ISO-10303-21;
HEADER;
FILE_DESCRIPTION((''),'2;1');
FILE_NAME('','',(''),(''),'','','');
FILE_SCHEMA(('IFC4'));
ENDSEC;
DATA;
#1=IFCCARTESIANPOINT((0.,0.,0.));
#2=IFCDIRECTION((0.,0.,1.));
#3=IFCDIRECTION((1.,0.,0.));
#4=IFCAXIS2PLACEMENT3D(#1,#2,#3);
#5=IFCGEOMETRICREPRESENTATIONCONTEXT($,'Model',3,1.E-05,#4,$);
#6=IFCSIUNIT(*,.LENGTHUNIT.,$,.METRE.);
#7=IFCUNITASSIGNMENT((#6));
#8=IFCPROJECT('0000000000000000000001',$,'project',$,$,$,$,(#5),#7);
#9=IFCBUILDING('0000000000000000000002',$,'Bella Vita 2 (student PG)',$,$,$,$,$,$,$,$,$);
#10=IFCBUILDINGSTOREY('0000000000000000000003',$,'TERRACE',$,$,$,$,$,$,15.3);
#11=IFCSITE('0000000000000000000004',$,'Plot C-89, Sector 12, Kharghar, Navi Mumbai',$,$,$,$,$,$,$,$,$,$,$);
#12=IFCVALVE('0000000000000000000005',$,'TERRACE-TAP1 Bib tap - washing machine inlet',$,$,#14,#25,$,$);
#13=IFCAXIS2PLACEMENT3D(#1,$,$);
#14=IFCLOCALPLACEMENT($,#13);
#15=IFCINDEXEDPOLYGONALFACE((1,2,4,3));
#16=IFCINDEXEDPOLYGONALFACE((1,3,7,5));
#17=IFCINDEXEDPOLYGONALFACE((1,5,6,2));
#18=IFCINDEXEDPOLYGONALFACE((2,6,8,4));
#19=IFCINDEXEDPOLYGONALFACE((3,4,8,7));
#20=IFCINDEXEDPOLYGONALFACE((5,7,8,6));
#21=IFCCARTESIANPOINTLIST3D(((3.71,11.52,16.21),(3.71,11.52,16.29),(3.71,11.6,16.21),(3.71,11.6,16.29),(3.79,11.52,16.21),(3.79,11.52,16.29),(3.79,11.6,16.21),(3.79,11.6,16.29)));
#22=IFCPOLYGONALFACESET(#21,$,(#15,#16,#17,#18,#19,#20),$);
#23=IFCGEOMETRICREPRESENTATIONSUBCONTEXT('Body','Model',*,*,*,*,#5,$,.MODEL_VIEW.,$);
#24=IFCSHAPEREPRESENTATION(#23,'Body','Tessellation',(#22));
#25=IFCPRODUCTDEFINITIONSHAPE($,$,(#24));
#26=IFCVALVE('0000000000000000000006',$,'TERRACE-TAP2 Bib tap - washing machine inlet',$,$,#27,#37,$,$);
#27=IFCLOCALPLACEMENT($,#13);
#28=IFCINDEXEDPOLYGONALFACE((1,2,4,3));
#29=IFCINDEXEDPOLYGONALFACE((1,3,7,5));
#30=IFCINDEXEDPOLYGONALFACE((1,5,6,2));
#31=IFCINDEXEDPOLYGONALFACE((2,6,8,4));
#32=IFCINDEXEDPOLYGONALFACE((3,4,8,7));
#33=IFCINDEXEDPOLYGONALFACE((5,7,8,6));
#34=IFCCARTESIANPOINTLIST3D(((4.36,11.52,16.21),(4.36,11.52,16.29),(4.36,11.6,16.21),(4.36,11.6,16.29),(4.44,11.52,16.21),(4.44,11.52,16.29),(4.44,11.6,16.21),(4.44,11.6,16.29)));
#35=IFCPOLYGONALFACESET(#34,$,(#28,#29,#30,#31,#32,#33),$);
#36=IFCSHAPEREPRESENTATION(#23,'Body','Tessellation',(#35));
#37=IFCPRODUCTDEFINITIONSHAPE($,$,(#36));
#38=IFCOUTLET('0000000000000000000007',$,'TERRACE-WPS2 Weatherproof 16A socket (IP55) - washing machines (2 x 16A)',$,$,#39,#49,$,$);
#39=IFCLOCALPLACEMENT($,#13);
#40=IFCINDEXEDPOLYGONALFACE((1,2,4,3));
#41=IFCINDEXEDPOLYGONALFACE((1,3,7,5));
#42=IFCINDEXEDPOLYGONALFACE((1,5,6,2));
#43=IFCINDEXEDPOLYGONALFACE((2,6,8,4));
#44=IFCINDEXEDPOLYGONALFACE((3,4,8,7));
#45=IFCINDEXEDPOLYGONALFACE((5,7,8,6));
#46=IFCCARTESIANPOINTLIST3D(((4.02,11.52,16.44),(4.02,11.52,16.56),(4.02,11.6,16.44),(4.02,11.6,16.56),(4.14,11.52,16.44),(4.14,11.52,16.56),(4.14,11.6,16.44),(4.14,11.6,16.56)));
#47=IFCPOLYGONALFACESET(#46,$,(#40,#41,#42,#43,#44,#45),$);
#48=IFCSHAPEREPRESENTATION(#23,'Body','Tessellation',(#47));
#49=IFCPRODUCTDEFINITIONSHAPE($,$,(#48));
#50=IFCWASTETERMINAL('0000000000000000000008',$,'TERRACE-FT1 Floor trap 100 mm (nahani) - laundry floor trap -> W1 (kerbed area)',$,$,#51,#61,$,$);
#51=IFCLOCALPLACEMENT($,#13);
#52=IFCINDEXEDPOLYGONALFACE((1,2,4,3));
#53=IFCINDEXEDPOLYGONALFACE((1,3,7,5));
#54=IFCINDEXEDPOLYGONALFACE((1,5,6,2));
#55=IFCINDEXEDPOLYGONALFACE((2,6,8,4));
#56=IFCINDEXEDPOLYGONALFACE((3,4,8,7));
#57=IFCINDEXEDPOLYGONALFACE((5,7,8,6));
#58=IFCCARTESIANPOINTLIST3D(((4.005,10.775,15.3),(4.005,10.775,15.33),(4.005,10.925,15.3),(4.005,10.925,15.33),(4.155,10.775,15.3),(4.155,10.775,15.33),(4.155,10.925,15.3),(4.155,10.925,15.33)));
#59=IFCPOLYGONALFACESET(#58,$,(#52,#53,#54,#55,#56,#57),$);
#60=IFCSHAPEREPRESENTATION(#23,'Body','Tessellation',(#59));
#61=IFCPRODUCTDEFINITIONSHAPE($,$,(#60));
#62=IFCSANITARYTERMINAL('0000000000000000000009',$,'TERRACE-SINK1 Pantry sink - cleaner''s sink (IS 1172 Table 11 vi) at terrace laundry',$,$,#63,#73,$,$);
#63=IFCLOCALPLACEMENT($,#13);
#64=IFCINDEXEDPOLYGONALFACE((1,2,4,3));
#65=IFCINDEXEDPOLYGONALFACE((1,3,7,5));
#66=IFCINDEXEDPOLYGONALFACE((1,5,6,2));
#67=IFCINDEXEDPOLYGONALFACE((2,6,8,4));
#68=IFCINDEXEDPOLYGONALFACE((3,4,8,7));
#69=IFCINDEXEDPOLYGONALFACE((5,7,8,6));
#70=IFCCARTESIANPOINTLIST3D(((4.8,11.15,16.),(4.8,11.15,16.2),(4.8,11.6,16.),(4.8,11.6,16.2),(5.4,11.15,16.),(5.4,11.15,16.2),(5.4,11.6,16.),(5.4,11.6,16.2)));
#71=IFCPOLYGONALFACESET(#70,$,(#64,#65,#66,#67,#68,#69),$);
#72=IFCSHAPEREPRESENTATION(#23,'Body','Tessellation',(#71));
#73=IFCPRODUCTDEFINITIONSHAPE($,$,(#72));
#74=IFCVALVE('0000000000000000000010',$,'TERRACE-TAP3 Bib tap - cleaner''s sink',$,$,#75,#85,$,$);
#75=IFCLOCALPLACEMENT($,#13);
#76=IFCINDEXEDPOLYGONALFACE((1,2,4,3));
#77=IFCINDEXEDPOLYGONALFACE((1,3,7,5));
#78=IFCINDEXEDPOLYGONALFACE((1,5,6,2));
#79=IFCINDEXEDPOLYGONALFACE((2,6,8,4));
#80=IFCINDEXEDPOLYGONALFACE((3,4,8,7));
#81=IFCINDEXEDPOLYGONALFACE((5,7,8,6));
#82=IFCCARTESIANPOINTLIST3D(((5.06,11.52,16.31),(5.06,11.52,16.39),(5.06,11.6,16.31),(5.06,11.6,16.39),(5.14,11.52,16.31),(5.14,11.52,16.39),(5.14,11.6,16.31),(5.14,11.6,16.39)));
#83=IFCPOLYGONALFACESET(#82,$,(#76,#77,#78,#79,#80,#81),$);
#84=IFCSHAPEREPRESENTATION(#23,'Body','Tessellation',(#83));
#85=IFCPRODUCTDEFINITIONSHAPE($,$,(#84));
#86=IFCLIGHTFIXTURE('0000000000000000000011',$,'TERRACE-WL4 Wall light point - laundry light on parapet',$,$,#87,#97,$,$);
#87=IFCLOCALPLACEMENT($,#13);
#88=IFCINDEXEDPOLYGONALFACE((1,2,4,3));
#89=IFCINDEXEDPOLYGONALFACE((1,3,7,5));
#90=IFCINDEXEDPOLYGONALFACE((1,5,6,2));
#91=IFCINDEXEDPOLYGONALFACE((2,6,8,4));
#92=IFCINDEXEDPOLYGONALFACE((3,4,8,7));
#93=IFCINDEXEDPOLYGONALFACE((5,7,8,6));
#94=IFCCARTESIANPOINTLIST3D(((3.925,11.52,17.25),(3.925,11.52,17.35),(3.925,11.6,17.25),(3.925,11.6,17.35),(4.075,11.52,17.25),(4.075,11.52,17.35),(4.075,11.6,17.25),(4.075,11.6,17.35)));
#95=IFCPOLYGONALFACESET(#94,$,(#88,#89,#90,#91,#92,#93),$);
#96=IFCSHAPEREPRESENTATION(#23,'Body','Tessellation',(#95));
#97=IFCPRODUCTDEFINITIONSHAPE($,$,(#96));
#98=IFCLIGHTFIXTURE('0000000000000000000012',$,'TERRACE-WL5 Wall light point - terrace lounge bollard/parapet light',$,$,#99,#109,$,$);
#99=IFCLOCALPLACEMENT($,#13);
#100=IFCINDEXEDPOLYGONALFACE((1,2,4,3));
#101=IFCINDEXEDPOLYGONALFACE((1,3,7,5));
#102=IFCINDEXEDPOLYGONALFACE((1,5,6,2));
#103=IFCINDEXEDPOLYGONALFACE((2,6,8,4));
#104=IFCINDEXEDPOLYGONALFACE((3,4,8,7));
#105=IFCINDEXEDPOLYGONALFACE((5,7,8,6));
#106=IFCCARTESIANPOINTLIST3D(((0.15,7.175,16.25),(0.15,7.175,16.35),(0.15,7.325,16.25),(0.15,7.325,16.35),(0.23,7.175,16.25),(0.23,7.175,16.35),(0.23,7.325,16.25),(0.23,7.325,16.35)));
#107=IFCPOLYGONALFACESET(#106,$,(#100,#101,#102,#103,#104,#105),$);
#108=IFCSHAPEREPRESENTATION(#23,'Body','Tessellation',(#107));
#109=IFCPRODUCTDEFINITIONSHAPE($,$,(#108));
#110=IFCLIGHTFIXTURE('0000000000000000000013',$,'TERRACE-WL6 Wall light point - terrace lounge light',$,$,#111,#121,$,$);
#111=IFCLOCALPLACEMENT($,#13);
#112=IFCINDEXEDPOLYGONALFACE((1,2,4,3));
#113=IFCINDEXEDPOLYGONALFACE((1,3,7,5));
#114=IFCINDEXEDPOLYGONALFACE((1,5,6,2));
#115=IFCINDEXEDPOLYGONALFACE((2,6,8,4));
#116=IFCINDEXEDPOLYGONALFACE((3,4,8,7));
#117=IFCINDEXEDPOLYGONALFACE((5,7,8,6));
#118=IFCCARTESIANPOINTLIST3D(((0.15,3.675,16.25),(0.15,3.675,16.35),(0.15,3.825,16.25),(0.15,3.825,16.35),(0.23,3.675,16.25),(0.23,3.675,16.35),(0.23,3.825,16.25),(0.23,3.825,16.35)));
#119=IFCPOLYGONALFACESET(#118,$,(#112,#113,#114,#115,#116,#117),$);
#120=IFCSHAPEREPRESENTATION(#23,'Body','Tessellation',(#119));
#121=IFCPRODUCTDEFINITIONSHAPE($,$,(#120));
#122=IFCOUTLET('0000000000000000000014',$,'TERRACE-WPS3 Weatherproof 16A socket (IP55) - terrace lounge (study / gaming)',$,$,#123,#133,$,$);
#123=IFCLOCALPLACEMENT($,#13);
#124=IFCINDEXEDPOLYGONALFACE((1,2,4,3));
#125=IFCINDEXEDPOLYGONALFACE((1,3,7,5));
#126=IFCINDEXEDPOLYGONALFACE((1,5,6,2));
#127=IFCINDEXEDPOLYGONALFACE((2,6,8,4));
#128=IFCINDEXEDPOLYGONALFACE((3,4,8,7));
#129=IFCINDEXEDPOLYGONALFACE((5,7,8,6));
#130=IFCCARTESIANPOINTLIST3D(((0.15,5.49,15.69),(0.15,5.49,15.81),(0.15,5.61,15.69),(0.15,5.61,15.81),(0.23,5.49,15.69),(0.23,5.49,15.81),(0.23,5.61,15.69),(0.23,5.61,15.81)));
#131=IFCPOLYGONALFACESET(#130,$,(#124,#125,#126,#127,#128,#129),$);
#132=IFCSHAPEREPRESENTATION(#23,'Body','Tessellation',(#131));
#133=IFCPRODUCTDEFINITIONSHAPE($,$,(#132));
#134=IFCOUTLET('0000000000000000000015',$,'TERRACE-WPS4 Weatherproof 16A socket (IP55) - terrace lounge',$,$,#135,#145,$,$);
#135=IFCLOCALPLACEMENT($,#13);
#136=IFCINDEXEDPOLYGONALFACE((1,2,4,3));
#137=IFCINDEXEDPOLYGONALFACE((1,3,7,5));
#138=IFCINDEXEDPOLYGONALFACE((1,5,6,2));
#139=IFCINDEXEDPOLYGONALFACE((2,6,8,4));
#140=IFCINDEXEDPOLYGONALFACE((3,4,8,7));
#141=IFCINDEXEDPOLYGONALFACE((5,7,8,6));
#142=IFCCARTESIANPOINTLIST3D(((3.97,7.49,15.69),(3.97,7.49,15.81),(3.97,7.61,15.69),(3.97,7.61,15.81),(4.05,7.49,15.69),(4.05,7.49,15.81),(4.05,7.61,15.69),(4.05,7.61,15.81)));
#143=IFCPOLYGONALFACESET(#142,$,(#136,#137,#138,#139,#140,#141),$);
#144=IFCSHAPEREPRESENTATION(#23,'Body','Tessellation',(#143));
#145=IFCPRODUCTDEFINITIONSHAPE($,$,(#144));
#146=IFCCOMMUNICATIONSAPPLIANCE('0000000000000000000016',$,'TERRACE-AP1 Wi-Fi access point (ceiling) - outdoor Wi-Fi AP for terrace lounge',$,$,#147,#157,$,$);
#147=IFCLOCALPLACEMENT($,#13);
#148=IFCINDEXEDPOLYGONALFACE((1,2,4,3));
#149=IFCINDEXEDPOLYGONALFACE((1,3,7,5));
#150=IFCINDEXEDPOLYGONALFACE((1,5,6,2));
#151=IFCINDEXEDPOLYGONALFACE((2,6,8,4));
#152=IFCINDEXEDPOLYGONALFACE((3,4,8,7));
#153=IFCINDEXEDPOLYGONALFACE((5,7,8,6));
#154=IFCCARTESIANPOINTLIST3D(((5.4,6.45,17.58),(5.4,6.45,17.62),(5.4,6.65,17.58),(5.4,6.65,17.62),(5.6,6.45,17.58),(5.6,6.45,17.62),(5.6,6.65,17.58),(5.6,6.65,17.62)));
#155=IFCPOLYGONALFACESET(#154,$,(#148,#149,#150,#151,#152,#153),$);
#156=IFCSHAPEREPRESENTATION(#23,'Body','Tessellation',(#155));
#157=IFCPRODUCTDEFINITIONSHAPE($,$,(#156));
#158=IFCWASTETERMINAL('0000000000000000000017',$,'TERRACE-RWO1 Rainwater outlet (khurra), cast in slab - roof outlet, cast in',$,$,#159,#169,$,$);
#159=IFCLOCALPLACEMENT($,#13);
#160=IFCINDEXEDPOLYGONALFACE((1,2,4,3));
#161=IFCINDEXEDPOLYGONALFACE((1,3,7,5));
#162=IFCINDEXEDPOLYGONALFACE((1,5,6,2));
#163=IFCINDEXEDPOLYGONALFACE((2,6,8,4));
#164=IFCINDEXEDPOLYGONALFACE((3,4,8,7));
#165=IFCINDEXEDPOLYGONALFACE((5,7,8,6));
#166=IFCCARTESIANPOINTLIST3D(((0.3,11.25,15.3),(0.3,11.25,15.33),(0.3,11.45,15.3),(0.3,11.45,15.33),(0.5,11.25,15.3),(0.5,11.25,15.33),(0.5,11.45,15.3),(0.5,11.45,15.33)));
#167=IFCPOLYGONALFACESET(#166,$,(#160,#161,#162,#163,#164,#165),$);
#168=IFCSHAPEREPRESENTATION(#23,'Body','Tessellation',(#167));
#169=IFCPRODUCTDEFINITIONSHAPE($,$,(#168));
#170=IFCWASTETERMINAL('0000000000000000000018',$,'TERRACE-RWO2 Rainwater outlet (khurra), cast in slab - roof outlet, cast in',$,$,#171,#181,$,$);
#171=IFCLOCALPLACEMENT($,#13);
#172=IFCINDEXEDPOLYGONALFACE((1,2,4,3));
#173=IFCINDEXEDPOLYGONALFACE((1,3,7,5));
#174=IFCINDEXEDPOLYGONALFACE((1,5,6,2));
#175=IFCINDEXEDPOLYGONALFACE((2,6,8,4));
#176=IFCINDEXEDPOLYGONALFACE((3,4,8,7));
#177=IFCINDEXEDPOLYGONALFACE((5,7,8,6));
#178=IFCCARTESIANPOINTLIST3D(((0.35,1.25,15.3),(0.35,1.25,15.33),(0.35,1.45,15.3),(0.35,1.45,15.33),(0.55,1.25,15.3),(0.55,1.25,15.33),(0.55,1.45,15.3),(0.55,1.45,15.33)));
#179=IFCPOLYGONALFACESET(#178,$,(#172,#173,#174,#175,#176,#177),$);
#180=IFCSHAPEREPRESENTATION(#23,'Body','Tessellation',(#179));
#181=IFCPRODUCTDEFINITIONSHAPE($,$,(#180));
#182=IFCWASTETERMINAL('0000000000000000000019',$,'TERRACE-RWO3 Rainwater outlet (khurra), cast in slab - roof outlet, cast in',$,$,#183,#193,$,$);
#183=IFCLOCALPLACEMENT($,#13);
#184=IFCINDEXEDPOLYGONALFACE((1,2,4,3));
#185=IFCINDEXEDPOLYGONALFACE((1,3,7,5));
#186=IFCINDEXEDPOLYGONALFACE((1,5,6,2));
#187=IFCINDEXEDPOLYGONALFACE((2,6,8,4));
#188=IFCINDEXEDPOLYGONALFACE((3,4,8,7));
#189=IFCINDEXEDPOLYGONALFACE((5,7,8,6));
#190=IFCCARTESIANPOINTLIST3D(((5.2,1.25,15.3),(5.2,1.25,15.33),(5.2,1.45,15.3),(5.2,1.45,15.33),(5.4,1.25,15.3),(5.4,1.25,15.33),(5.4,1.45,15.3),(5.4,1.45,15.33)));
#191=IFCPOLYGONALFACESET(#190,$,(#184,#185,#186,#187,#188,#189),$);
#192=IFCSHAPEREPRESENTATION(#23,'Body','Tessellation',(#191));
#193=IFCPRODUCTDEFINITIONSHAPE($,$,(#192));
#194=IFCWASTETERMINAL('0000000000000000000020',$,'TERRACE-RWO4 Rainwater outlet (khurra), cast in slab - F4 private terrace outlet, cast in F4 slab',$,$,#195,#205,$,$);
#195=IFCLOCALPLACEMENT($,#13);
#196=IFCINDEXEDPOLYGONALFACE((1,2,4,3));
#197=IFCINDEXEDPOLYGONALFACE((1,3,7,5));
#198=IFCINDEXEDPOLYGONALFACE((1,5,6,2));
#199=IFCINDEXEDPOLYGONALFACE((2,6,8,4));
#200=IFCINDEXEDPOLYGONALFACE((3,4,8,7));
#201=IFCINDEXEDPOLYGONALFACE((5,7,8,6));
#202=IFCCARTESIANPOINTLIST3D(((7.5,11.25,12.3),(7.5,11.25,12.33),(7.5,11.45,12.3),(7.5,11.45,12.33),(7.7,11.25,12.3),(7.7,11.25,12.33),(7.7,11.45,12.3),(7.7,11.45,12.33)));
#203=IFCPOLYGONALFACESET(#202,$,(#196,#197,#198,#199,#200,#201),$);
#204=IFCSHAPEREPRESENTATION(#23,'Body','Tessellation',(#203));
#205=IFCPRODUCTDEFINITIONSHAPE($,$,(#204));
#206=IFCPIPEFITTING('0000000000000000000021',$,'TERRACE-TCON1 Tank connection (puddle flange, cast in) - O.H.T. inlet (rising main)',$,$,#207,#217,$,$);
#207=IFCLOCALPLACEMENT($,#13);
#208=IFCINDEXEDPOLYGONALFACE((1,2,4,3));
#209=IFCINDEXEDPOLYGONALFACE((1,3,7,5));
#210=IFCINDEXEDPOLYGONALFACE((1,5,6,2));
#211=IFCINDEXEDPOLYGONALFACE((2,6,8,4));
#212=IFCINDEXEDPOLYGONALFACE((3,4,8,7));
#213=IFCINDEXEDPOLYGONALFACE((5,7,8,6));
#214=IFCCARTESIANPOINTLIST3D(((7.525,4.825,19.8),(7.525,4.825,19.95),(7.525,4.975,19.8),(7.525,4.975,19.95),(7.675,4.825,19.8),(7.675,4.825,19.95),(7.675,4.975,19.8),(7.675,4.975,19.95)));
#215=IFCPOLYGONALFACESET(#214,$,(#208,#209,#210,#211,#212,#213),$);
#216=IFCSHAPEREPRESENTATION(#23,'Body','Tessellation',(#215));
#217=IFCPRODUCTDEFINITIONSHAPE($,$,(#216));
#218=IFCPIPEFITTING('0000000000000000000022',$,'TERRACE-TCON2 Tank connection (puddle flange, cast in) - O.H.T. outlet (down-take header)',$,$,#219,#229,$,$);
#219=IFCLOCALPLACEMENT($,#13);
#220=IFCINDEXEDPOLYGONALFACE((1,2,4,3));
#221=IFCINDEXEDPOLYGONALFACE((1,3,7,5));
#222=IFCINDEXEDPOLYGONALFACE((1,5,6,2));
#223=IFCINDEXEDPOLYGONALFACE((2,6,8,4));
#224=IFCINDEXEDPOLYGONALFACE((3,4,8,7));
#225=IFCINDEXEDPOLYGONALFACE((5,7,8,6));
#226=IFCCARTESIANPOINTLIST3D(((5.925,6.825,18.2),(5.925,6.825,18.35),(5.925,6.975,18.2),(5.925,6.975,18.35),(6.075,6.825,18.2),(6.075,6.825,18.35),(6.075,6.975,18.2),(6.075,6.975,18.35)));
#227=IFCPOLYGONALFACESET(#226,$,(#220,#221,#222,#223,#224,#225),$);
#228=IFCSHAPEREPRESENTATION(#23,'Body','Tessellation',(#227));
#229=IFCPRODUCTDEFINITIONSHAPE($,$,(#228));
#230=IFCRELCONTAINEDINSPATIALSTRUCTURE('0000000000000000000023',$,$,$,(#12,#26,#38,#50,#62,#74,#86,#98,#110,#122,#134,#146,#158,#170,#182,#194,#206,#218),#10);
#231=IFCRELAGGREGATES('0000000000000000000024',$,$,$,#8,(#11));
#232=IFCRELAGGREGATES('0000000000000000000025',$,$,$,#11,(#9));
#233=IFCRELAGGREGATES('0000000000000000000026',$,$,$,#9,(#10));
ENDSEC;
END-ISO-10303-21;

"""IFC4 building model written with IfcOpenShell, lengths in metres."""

from ifc_helpers import new_model, si_unit, frame, origin, origin_with_axes, origin_2d, place, context, subcontext, project, spatial, rectangle, extrude, element, save


model = new_model("IFC4")

# Units and contexts
model_context = context("Model", 3, precision=1e-05, world=origin_with_axes())
body_context = subcontext(model_context, "Body", "Model", "MODEL_VIEW")
ifc_project = project(units=[si_unit("LENGTHUNIT", "METRE")], contexts=[model_context])

# Site, building, storey
site = spatial("IfcSite", under=ifc_project, Name="Plot C-89, Sector 12, Kharghar, Navi Mumbai")
building = spatial("IfcBuilding", under=site, Name="Bella Vita 2 (student PG)")
storey = spatial("IfcBuildingStorey", under=building, Name="TERRACE", Elevation=15.3)

# Valves
valve_1_placement = place(None, origin())
element("IfcValve", 1, at=valve_1_placement, inside=storey, Name="TERRACE-TAP1 Bib tap - washing machine inlet", context=body_context, shape_type="SweptSolid", body=[
    extrude(rectangle(XDim=0.08, YDim=0.08, at=origin_2d()), frame((3.75, 11.56, 16.21)), (0.0, 0.0, 1.0), 0.08),
])
valve_2_placement = place(None, origin())
element("IfcValve", 2, at=valve_2_placement, inside=storey, Name="TERRACE-TAP2 Bib tap - washing machine inlet", context=body_context, shape_type="SweptSolid", body=[
    extrude(rectangle(XDim=0.08, YDim=0.08, at=origin_2d()), frame((4.4, 11.56, 16.21)), (0.0, 0.0, 1.0), 0.08),
])

# Outlet
outlet_1_placement = place(None, origin())
element("IfcOutlet", 3, at=outlet_1_placement, inside=storey, Name="TERRACE-WPS2 Weatherproof 16A socket (IP55) - washing machines (2 x 16A)", context=body_context, shape_type="SweptSolid", body=[
    extrude(rectangle(XDim=0.12, YDim=0.08, at=origin_2d()), frame((4.08, 11.56, 16.44)), (0.0, 0.0, 1.0), 0.12),
])

# Waste terminal
waste_terminal_1_placement = place(None, origin())
element("IfcWasteTerminal", 4, at=waste_terminal_1_placement, inside=storey, Name="TERRACE-FT1 Floor trap 100 mm (nahani) - laundry floor trap -> W1 (kerbed area)", context=body_context, shape_type="SweptSolid", body=[
    extrude(rectangle(XDim=0.15, YDim=0.15, at=origin_2d()), frame((4.08, 10.85, 15.3)), (0.0, 0.0, 1.0), 0.03),
])

# Sanitary terminal
sanitary_terminal_placement = place(None, origin())
element("IfcSanitaryTerminal", 5, at=sanitary_terminal_placement, inside=storey, Name="TERRACE-SINK1 Pantry sink - cleaner's sink (IS 1172 Table 11 vi) at terrace laundry", context=body_context, shape_type="SweptSolid", body=[
    extrude(rectangle(XDim=0.6, YDim=0.45, at=origin_2d()), frame((5.1, 11.375, 16.0)), (0.0, 0.0, 1.0), 0.2),
])

# Valve
valve_3_placement = place(None, origin())
element("IfcValve", 6, at=valve_3_placement, inside=storey, Name="TERRACE-TAP3 Bib tap - cleaner's sink", context=body_context, shape_type="SweptSolid", body=[
    extrude(rectangle(XDim=0.08, YDim=0.08, at=origin_2d()), frame((5.1, 11.56, 16.31)), (0.0, 0.0, 1.0), 0.08),
])

# Light fixtures
light_fixture_1_placement = place(None, origin())
element("IfcLightFixture", 7, at=light_fixture_1_placement, inside=storey, Name="TERRACE-WL4 Wall light point - laundry light on parapet", context=body_context, shape_type="SweptSolid", body=[
    extrude(rectangle(XDim=0.15, YDim=0.08, at=origin_2d()), frame((4.0, 11.56, 17.25)), (0.0, 0.0, 1.0), 0.1),
])
light_fixture_2_placement = place(None, origin())
element("IfcLightFixture", 8, at=light_fixture_2_placement, inside=storey, Name="TERRACE-WL5 Wall light point - terrace lounge bollard/parapet light", context=body_context, shape_type="SweptSolid", body=[
    extrude(rectangle(XDim=0.08, YDim=0.15, at=origin_2d()), frame((0.19, 7.25, 16.25)), (0.0, 0.0, 1.0), 0.1),
])
light_fixture_3_placement = place(None, origin())
element("IfcLightFixture", 9, at=light_fixture_3_placement, inside=storey, Name="TERRACE-WL6 Wall light point - terrace lounge light", context=body_context, shape_type="SweptSolid", body=[
    extrude(rectangle(XDim=0.08, YDim=0.15, at=origin_2d()), frame((0.19, 3.75, 16.25)), (0.0, 0.0, 1.0), 0.1),
])

# Outlets
outlet_2_placement = place(None, origin())
element("IfcOutlet", 10, at=outlet_2_placement, inside=storey, Name="TERRACE-WPS3 Weatherproof 16A socket (IP55) - terrace lounge (study / gaming)", context=body_context, shape_type="SweptSolid", body=[
    extrude(rectangle(XDim=0.08, YDim=0.12, at=origin_2d()), frame((0.19, 5.55, 15.69)), (0.0, 0.0, 1.0), 0.12),
])
outlet_3_placement = place(None, origin())
element("IfcOutlet", 11, at=outlet_3_placement, inside=storey, Name="TERRACE-WPS4 Weatherproof 16A socket (IP55) - terrace lounge", context=body_context, shape_type="SweptSolid", body=[
    extrude(rectangle(XDim=0.08, YDim=0.12, at=origin_2d()), frame((4.01, 7.55, 15.69)), (0.0, 0.0, 1.0), 0.12),
])

# Communications appliance
communications_appliance_placement = place(None, origin())
element("IfcCommunicationsAppliance", 12, at=communications_appliance_placement, inside=storey, Name="TERRACE-AP1 Wi-Fi access point (ceiling) - outdoor Wi-Fi AP for terrace lounge", context=body_context, shape_type="SweptSolid", body=[
    extrude(rectangle(XDim=0.2, YDim=0.2, at=origin_2d()), frame((5.5, 6.55, 17.58)), (0.0, 0.0, 1.0), 0.04),
])

# Waste terminals
waste_terminal_2_placement = place(None, origin())
element("IfcWasteTerminal", 13, at=waste_terminal_2_placement, inside=storey, Name="TERRACE-RWO1 Rainwater outlet (khurra), cast in slab - roof outlet, cast in", context=body_context, shape_type="SweptSolid", body=[
    extrude(rectangle(XDim=0.2, YDim=0.2, at=origin_2d()), frame((0.4, 11.35, 15.3)), (0.0, 0.0, 1.0), 0.03),
])
waste_terminal_3_placement = place(None, origin())
element("IfcWasteTerminal", 14, at=waste_terminal_3_placement, inside=storey, Name="TERRACE-RWO2 Rainwater outlet (khurra), cast in slab - roof outlet, cast in", context=body_context, shape_type="SweptSolid", body=[
    extrude(rectangle(XDim=0.2, YDim=0.2, at=origin_2d()), frame((0.45, 1.35, 15.3)), (0.0, 0.0, 1.0), 0.03),
])
waste_terminal_4_placement = place(None, origin())
element("IfcWasteTerminal", 15, at=waste_terminal_4_placement, inside=storey, Name="TERRACE-RWO3 Rainwater outlet (khurra), cast in slab - roof outlet, cast in", context=body_context, shape_type="SweptSolid", body=[
    extrude(rectangle(XDim=0.2, YDim=0.2, at=origin_2d()), frame((5.3, 1.35, 15.3)), (0.0, 0.0, 1.0), 0.03),
])
waste_terminal_5_placement = place(None, origin())
element("IfcWasteTerminal", 16, at=waste_terminal_5_placement, inside=storey, Name="TERRACE-RWO4 Rainwater outlet (khurra), cast in slab - F4 private terrace outlet, cast in F4 slab", context=body_context, shape_type="SweptSolid", body=[
    extrude(rectangle(XDim=0.2, YDim=0.2, at=origin_2d()), frame((7.6, 11.35, 12.3)), (0.0, 0.0, 1.0), 0.03),
])

# Pipe fittings
pipe_fitting_1_placement = place(None, origin())
element("IfcPipeFitting", 17, at=pipe_fitting_1_placement, inside=storey, Name="TERRACE-TCON1 Tank connection (puddle flange, cast in) - O.H.T. inlet (rising main)", context=body_context, shape_type="SweptSolid", body=[
    extrude(rectangle(XDim=0.15, YDim=0.15, at=origin_2d()), frame((7.6, 4.9, 19.8)), (0.0, 0.0, 1.0), 0.15),
])
pipe_fitting_2_placement = place(None, origin())
element("IfcPipeFitting", 18, at=pipe_fitting_2_placement, inside=storey, Name="TERRACE-TCON2 Tank connection (puddle flange, cast in) - O.H.T. outlet (down-take header)", context=body_context, shape_type="SweptSolid", body=[
    extrude(rectangle(XDim=0.15, YDim=0.15, at=origin_2d()), frame((6.0, 6.9, 18.2)), (0.0, 0.0, 1.0), 0.15),
])

save(model, "model.ifc")
